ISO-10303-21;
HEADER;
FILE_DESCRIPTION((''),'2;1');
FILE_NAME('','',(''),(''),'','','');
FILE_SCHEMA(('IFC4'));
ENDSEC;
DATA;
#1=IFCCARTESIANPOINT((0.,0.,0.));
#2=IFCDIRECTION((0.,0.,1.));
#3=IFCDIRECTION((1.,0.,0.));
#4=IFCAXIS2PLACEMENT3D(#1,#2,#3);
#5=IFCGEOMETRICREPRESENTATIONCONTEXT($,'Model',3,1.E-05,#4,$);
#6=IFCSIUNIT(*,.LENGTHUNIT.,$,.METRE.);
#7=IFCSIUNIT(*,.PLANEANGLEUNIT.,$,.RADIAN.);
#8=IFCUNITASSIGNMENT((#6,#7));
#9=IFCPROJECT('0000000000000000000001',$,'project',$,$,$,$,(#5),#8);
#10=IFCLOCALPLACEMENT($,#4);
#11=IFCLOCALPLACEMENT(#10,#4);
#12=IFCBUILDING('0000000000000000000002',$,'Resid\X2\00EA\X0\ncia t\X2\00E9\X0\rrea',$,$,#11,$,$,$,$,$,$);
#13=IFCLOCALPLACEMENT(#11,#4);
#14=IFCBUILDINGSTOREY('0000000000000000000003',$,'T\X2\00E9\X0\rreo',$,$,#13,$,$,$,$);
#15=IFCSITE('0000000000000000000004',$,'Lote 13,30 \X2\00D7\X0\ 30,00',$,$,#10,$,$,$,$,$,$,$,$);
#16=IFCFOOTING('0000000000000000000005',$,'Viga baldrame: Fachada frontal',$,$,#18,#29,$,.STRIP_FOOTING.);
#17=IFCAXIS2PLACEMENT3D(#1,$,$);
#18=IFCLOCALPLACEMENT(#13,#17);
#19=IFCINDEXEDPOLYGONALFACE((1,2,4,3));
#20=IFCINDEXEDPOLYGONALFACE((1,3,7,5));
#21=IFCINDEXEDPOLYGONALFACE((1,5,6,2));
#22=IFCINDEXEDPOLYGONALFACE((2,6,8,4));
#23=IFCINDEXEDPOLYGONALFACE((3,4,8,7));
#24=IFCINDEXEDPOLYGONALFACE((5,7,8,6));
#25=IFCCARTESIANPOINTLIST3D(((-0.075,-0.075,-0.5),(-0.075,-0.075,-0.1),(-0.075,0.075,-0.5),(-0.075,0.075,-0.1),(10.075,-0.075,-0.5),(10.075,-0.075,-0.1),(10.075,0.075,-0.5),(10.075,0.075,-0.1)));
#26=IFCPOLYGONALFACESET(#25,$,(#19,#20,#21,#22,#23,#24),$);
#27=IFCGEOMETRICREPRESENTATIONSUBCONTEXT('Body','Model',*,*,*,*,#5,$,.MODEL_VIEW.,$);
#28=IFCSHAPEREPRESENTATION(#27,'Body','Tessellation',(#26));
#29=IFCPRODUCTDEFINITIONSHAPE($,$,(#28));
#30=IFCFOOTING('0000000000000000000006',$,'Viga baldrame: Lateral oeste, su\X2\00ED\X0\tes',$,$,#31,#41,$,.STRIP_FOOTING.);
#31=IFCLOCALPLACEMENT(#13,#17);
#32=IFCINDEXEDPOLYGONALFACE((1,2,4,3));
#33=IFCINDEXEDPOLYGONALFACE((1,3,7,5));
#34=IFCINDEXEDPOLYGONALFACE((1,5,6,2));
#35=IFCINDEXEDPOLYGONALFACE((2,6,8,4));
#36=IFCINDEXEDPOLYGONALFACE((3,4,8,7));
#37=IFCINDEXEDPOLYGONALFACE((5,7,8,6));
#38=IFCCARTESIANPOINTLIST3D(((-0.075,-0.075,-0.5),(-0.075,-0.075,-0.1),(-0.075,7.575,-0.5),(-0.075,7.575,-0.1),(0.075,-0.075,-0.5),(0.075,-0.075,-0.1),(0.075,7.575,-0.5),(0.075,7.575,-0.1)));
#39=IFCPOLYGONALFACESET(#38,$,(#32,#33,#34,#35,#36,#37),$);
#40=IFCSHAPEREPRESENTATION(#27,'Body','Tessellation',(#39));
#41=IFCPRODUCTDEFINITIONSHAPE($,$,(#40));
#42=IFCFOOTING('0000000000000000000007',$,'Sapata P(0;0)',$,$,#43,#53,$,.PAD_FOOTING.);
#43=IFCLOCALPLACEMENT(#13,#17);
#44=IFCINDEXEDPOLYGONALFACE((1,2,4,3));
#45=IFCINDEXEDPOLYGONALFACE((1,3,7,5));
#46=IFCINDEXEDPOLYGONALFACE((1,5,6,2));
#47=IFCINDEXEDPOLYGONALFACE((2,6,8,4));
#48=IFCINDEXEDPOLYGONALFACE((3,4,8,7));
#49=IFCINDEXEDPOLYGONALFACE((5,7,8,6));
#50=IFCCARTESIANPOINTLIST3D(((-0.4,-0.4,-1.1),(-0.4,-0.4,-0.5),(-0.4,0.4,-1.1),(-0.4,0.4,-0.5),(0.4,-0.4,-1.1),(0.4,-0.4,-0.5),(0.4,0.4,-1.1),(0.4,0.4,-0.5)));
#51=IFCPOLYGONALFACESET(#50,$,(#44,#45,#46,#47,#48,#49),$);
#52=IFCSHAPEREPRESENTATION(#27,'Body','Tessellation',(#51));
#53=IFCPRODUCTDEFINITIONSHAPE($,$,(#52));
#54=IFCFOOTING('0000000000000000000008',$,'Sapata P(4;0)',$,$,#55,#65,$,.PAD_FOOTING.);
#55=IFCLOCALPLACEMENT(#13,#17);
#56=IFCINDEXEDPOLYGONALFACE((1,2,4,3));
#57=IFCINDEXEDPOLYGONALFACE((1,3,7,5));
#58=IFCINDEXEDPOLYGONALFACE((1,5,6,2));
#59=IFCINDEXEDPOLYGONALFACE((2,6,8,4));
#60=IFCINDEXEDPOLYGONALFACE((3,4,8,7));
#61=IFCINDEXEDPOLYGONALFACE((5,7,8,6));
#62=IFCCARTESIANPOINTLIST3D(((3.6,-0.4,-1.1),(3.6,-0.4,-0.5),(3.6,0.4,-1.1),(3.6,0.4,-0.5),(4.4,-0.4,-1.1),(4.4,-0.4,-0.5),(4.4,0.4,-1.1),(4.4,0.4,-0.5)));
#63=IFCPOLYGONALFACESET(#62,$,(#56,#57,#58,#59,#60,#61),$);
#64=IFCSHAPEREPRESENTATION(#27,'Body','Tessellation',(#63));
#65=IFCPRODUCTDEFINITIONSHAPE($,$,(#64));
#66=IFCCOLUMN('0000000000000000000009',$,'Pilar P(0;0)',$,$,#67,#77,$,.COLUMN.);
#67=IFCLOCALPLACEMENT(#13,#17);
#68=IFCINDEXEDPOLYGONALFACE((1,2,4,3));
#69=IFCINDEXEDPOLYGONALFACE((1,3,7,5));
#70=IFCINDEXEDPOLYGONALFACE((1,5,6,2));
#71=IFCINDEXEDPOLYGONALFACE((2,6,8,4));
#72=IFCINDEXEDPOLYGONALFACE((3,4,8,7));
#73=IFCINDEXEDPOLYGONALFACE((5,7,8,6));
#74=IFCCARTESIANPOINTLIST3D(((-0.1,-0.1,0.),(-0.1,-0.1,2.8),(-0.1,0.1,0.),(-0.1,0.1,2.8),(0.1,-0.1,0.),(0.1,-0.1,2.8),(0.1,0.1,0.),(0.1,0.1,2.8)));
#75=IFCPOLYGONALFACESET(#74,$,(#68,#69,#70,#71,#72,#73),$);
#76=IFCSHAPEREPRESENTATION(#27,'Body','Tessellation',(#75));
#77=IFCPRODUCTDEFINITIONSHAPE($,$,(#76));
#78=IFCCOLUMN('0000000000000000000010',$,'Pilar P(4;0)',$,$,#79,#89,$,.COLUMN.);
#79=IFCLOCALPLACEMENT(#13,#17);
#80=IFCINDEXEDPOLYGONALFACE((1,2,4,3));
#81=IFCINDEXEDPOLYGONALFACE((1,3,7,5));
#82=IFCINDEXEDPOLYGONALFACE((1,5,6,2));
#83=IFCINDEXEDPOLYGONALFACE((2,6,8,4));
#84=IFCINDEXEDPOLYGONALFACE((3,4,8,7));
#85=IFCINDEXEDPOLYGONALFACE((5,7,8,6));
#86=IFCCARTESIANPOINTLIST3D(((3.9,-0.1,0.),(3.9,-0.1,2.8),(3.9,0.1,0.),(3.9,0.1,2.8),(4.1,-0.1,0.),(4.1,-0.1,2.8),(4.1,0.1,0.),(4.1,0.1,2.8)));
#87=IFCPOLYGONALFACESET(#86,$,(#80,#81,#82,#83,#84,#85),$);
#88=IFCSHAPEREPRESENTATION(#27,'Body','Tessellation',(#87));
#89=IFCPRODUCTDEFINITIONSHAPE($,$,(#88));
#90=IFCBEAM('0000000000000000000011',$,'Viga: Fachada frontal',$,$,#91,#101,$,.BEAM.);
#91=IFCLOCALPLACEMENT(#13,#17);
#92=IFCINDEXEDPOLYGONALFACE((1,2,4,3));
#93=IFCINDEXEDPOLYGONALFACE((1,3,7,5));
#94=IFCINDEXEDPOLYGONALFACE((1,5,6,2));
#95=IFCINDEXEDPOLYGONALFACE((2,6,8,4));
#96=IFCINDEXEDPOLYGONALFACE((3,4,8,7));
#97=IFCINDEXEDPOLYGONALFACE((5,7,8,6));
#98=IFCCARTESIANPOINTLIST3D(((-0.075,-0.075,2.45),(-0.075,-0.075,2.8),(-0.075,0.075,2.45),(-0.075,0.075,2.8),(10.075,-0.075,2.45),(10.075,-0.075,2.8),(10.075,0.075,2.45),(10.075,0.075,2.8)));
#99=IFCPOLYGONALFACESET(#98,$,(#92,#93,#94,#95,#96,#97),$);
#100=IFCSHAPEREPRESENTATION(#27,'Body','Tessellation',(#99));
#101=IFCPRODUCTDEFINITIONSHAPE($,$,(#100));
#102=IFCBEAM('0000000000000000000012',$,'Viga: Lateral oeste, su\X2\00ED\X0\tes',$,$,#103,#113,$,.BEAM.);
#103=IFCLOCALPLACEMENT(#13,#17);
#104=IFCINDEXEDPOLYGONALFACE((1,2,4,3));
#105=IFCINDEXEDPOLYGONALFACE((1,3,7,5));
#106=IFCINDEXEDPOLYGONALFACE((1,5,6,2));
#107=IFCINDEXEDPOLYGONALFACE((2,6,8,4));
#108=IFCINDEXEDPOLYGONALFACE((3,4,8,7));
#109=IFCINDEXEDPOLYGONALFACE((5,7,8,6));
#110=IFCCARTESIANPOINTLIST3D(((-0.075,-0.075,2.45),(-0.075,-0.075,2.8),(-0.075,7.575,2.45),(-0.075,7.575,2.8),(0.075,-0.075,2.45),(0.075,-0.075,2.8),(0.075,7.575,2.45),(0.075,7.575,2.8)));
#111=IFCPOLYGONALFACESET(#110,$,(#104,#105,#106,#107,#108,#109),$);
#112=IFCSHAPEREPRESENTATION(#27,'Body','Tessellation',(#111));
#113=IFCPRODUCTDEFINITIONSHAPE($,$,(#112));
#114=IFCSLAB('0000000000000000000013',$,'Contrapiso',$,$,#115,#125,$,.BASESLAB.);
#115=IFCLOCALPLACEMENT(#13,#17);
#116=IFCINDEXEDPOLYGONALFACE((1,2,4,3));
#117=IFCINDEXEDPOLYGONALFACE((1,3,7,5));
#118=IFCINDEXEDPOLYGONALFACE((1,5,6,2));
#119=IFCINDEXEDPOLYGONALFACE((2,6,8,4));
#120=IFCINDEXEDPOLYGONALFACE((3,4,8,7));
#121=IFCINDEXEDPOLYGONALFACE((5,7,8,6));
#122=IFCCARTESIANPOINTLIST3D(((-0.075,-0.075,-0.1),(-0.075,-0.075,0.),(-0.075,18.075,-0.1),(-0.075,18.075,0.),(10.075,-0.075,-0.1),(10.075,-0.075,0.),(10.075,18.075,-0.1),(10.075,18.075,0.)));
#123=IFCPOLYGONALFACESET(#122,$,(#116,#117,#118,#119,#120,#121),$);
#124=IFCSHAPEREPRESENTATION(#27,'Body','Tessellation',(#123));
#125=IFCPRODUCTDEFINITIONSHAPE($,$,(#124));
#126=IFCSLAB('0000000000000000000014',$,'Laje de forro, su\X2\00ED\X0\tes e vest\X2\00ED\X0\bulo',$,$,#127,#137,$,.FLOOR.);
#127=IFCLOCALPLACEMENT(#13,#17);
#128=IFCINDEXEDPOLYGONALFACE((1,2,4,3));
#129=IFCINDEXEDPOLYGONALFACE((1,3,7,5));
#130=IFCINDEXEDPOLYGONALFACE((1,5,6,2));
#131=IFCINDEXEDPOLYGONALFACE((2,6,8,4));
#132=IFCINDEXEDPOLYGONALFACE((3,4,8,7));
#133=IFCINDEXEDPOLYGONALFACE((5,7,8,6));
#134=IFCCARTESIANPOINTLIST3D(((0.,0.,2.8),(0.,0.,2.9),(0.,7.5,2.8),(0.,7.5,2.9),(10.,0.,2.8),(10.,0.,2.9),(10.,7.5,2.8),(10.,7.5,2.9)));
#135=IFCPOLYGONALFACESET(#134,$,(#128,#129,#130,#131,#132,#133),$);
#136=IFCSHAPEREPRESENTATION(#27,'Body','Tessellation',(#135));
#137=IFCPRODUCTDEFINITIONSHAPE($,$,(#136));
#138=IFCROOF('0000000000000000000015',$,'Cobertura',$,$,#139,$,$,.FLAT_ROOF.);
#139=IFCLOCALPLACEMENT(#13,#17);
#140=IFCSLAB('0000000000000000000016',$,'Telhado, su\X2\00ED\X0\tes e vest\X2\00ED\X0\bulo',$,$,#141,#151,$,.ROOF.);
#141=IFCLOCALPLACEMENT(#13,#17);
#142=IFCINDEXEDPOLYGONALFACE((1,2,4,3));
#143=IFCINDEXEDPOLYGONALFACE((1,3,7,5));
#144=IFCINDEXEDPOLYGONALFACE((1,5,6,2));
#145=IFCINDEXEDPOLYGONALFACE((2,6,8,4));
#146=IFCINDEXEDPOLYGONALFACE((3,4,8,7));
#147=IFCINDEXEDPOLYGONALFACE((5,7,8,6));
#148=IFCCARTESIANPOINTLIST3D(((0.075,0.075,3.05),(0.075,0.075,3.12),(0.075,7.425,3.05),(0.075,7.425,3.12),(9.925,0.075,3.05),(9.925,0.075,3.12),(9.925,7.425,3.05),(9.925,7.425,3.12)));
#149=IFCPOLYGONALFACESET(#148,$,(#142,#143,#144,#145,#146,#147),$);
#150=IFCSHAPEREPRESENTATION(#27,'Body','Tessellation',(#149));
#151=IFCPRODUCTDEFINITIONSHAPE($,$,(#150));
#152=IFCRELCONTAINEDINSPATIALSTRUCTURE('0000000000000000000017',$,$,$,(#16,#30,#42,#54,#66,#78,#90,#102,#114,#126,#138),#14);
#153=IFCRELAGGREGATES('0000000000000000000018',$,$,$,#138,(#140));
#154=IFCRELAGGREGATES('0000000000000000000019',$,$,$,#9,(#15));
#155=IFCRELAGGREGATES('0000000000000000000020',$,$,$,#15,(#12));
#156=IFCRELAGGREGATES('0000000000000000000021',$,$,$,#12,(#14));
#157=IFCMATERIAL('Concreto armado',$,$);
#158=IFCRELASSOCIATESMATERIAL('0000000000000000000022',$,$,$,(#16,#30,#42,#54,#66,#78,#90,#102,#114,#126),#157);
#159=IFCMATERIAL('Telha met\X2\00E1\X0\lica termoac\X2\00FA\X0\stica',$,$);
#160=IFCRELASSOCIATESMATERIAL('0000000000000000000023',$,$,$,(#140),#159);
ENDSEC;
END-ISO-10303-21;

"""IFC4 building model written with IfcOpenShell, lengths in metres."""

from ifc_helpers import new_model, si_unit, frame, origin_with_axes, place, context, subcontext, project, spatial, line, indexed_curve, outline, extrude, material, element, aggregate, save


model = new_model("IFC4")

# Units and contexts
model_context = context("Model", 3, precision=1e-05, world=origin_with_axes())
body_context = subcontext(model_context, "Body", "Model", "MODEL_VIEW")
ifc_project = project(units=[si_unit("LENGTHUNIT", "METRE"), si_unit("PLANEANGLEUNIT", "RADIAN")], contexts=[model_context])

# Site, building, storey
site_placement = place(None, origin_with_axes())
site = spatial("IfcSite", under=ifc_project, at=site_placement, Name="Lote 13,30 × 30,00")
building_placement = place(site_placement, origin_with_axes())
building = spatial("IfcBuilding", under=site, at=building_placement, Name="Residência térrea")
storey_placement = place(building_placement, origin_with_axes())
storey = spatial("IfcBuildingStorey", under=building, at=storey_placement, Name="Térreo")

# Footings
ifc_material_1 = material(Name="Concreto armado")
footing_1_placement = place(storey_placement, frame((-0.075, -0.075, -0.5), z_axis=(0.0, 0.0, 1.0), x_axis=(1.0, 0.0, 0.0)))
element("IfcFooting", 1, at=footing_1_placement, inside=storey, material=ifc_material_1, Name="Viga baldrame: Fachada frontal", PredefinedType="STRIP_FOOTING", context=body_context, shape_type="SweptSolid", body=[
    extrude(outline(indexed_curve([(0.0, 0.0), (10.15, 0.0), (10.15, 0.15), (0.0, 0.15)], segments=[line(1, 2, 3, 4, 1)])), origin_with_axes(), (0.0, 0.0, 1.0), 0.4),
])
footing_2_placement = place(storey_placement, frame((-0.075, -0.075, -0.5), z_axis=(0.0, 0.0, 1.0), x_axis=(1.0, 0.0, 0.0)))
element("IfcFooting", 2, at=footing_2_placement, inside=storey, material=ifc_material_1, Name="Viga baldrame: Lateral oeste, suítes", PredefinedType="STRIP_FOOTING", context=body_context, shape_type="SweptSolid", body=[
    extrude(outline(indexed_curve([(0.0, 0.0), (0.15, 0.0), (0.15, 7.65), (0.0, 7.65)], segments=[line(1, 2, 3, 4, 1)])), origin_with_axes(), (0.0, 0.0, 1.0), 0.4),
])
footing_3_placement = place(storey_placement, frame((-0.4, -0.4, -1.1), z_axis=(0.0, 0.0, 1.0), x_axis=(1.0, 0.0, 0.0)))
element("IfcFooting", 3, at=footing_3_placement, inside=storey, material=ifc_material_1, Name="Sapata P(0;0)", PredefinedType="PAD_FOOTING", context=body_context, shape_type="SweptSolid", body=[
    extrude(outline(indexed_curve([(0.0, 0.0), (0.8, 0.0), (0.8, 0.8), (0.0, 0.8)], segments=[line(1, 2, 3, 4, 1)])), origin_with_axes(), (0.0, 0.0, 1.0), 0.6),
])
footing_4_placement = place(storey_placement, frame((3.6, -0.4, -1.1), z_axis=(0.0, 0.0, 1.0), x_axis=(1.0, 0.0, 0.0)))
element("IfcFooting", 4, at=footing_4_placement, inside=storey, material=ifc_material_1, Name="Sapata P(4;0)", PredefinedType="PAD_FOOTING", context=body_context, shape_type="SweptSolid", body=[
    extrude(outline(indexed_curve([(0.0, 0.0), (0.8, 0.0), (0.8, 0.8), (0.0, 0.8)], segments=[line(1, 2, 3, 4, 1)])), origin_with_axes(), (0.0, 0.0, 1.0), 0.6),
])

# Columns
column_1_placement = place(storey_placement, frame((-0.1, -0.1, 0.0), z_axis=(0.0, 0.0, 1.0), x_axis=(1.0, 0.0, 0.0)))
element("IfcColumn", 5, at=column_1_placement, inside=storey, material=ifc_material_1, Name="Pilar P(0;0)", PredefinedType="COLUMN", context=body_context, shape_type="SweptSolid", body=[
    extrude(outline(indexed_curve([(0.0, 0.0), (0.2, 0.0), (0.2, 0.2), (0.0, 0.2)], segments=[line(1, 2, 3, 4, 1)])), origin_with_axes(), (0.0, 0.0, 1.0), 2.8),
])
column_2_placement = place(storey_placement, frame((3.9, -0.1, 0.0), z_axis=(0.0, 0.0, 1.0), x_axis=(1.0, 0.0, 0.0)))
element("IfcColumn", 6, at=column_2_placement, inside=storey, material=ifc_material_1, Name="Pilar P(4;0)", PredefinedType="COLUMN", context=body_context, shape_type="SweptSolid", body=[
    extrude(outline(indexed_curve([(0.0, 0.0), (0.2, 0.0), (0.2, 0.2), (0.0, 0.2)], segments=[line(1, 2, 3, 4, 1)])), origin_with_axes(), (0.0, 0.0, 1.0), 2.8),
])

# Beams
beam_1_placement = place(storey_placement, frame((-0.075, -0.075, 2.45), z_axis=(0.0, 0.0, 1.0), x_axis=(1.0, 0.0, 0.0)))
element("IfcBeam", 7, at=beam_1_placement, inside=storey, material=ifc_material_1, Name="Viga: Fachada frontal", PredefinedType="BEAM", context=body_context, shape_type="SweptSolid", body=[
    extrude(outline(indexed_curve([(0.0, 0.0), (10.15, 0.0), (10.15, 0.15), (0.0, 0.15)], segments=[line(1, 2, 3, 4, 1)])), origin_with_axes(), (0.0, 0.0, 1.0), 0.35),
])
beam_2_placement = place(storey_placement, frame((-0.075, -0.075, 2.45), z_axis=(0.0, 0.0, 1.0), x_axis=(1.0, 0.0, 0.0)))
element("IfcBeam", 8, at=beam_2_placement, inside=storey, material=ifc_material_1, Name="Viga: Lateral oeste, suítes", PredefinedType="BEAM", context=body_context, shape_type="SweptSolid", body=[
    extrude(outline(indexed_curve([(0.0, 0.0), (0.15, 0.0), (0.15, 7.65), (0.0, 7.65)], segments=[line(1, 2, 3, 4, 1)])), origin_with_axes(), (0.0, 0.0, 1.0), 0.35),
])

# Slabs
slab_1_placement = place(storey_placement, frame((-0.075, -0.075, -0.1), z_axis=(0.0, 0.0, 1.0), x_axis=(1.0, 0.0, 0.0)))
element("IfcSlab", 9, at=slab_1_placement, inside=storey, material=ifc_material_1, Name="Contrapiso", PredefinedType="BASESLAB", context=body_context, shape_type="SweptSolid", body=[
    extrude(outline(indexed_curve([(0.0, 0.0), (10.15, 0.0), (10.15, 18.15), (0.0, 18.15)], segments=[line(1, 2, 3, 4, 1)])), origin_with_axes(), (0.0, 0.0, 1.0), 0.1),
])
slab_2_placement = place(storey_placement, frame((0.0, 0.0, 2.8), z_axis=(0.0, 0.0, 1.0), x_axis=(1.0, 0.0, 0.0)))
element("IfcSlab", 10, at=slab_2_placement, inside=storey, material=ifc_material_1, Name="Laje de forro, suítes e vestíbulo", PredefinedType="FLOOR", context=body_context, shape_type="SweptSolid", body=[
    extrude(outline(indexed_curve([(0.0, 0.0), (10.0, 0.0), (10.0, 7.5), (0.0, 7.5)], segments=[line(1, 2, 3, 4, 1)])), origin_with_axes(), (0.0, 0.0, 1.0), 0.1),
])

# Roof, slab
roof_placement = place(storey_placement, origin_with_axes())
roof = element("IfcRoof", 11, at=roof_placement, inside=storey, Name="Cobertura", PredefinedType="FLAT_ROOF")
ifc_material_2 = material(Name="Telha metálica termoacústica")
slab_3_placement = place(roof_placement, frame((0.075, 0.075, 3.05), z_axis=(0.0, 0.0, 1.0), x_axis=(1.0, 0.0, 0.0)))
slab_3 = element("IfcSlab", 12, at=slab_3_placement, material=ifc_material_2, Name="Telhado, suítes e vestíbulo", PredefinedType="ROOF", context=body_context, shape_type="SweptSolid", body=[
    extrude(outline(indexed_curve([(0.0, 0.0), (9.85, 0.0), (9.85, 7.35), (0.0, 7.35)], segments=[line(1, 2, 3, 4, 1)])), origin_with_axes(), (0.0, 0.0, 1.0), 0.07),
])
aggregate(roof, [slab_3])

save(model, "model.ifc")
